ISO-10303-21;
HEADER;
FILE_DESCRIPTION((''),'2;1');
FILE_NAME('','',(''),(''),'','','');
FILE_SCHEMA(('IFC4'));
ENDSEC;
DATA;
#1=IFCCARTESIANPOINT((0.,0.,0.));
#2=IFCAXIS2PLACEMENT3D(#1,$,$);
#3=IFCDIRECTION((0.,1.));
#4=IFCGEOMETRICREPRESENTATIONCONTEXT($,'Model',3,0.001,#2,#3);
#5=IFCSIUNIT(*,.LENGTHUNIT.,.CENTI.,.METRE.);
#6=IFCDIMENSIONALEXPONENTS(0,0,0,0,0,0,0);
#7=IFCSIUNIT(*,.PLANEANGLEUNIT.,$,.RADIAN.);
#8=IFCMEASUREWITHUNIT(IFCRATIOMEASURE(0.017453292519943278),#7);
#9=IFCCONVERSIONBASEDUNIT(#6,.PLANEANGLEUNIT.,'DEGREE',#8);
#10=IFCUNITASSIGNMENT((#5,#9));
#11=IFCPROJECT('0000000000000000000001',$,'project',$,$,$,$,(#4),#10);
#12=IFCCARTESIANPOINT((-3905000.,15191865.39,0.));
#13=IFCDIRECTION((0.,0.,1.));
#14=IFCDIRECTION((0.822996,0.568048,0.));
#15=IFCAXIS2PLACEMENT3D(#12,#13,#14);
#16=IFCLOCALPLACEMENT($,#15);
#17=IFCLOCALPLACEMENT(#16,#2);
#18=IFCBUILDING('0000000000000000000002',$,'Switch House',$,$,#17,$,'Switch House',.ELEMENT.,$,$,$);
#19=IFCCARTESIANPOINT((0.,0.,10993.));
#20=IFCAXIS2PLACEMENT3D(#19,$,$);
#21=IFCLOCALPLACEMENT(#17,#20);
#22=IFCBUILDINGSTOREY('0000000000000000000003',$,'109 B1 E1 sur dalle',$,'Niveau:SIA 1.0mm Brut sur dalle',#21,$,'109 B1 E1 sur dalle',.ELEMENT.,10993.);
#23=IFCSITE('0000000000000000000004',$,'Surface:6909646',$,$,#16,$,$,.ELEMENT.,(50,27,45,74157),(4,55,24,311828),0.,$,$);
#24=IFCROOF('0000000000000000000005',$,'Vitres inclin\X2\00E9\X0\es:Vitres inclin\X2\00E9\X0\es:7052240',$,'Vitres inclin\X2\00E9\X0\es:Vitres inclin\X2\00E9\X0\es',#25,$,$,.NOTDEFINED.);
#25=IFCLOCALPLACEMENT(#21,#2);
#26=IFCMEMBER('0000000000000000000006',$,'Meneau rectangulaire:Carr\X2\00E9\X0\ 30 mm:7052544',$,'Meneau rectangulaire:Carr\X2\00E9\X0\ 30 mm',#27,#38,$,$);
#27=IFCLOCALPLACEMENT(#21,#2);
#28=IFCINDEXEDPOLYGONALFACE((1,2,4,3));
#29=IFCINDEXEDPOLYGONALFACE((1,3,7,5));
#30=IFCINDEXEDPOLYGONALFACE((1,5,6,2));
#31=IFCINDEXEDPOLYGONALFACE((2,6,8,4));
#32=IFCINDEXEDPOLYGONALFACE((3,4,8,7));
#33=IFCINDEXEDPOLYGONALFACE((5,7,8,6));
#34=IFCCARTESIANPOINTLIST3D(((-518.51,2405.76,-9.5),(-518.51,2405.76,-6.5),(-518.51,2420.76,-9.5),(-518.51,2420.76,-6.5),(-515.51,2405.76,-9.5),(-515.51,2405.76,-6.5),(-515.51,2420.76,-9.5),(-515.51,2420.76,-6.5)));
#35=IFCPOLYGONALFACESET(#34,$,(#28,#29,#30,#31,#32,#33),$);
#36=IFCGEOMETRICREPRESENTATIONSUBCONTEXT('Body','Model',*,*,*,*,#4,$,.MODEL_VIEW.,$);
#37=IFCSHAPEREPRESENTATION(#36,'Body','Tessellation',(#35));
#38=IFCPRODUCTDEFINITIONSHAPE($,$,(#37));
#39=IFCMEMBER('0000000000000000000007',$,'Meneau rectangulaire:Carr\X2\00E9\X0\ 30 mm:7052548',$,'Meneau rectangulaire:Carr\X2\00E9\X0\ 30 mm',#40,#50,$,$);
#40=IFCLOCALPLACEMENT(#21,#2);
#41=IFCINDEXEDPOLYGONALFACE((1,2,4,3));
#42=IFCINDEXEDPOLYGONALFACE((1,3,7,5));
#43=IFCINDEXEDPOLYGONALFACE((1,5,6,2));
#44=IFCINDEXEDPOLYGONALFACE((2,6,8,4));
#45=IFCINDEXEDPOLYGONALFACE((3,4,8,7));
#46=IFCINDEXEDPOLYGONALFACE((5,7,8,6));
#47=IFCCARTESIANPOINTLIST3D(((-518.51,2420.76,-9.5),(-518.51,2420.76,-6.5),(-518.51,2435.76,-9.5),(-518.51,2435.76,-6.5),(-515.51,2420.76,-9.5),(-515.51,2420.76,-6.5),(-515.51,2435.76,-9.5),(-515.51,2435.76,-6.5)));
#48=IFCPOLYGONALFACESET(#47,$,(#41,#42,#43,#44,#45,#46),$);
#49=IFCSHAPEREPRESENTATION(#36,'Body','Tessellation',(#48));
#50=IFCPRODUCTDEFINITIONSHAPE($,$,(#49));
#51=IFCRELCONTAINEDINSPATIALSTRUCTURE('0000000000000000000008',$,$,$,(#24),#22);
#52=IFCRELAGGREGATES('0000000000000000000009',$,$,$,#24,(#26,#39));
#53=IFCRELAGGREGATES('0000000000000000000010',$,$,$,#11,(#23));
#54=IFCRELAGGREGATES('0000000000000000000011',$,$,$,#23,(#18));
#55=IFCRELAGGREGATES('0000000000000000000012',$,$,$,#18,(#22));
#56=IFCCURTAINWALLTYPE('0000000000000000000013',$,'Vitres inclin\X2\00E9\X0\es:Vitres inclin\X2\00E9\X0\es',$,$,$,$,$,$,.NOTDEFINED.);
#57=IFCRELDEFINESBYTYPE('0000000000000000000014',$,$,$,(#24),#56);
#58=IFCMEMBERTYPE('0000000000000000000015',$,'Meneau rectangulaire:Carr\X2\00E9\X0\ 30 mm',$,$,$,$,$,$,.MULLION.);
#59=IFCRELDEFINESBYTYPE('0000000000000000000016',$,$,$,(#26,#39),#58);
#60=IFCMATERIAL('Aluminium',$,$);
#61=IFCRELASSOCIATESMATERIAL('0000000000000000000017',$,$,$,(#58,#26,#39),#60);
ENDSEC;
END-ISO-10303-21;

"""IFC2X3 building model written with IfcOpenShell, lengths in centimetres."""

from ifc_helpers import new_model, entity, si_unit, converted_unit, direction, frame, origin, origin_2d_with_axis, place, context, subcontext, project, spatial, rectangle, extrude, source, transform, mapped, material, type_object, type_shapes, element, aggregate, save


model = new_model("IFC2X3")

# Units and contexts
model_context = context("Model", 3, precision=0.001, world=origin(), true_north=direction((0.0, 1.0)))
body_context = subcontext(model_context, "Body", "Model", "MODEL_VIEW")
ifc_project = project(units=[si_unit("LENGTHUNIT", "METRE", prefix="CENTI"), converted_unit("PLANEANGLEUNIT", "DEGREE", entity("IfcRatioMeasure", 0.017453292519943278), si_unit("PLANEANGLEUNIT", "RADIAN"), dimensions=[0, 0, 0, 0, 0, 0, 0])], contexts=[model_context])

# Site, building, storey
site_placement = place(None, frame((-3905000.0, 15191865.39, 0.0), z_axis=(0.0, 0.0, 1.0), x_axis=(0.822996, 0.568048, 0.0)))
site = spatial("IfcSite", under=ifc_project, at=site_placement, Name="Surface:6909646", CompositionType="ELEMENT", RefLatitude=(50, 27, 45, 74157), RefLongitude=(4, 55, 24, 311828), RefElevation=0.0)
building_placement = place(site_placement, origin())
building = spatial("IfcBuilding", under=site, at=building_placement, Name="Switch House", LongName="Switch House", CompositionType="ELEMENT")
storey_placement = place(building_placement, frame((0.0, 0.0, 10993.0)))
storey = spatial("IfcBuildingStorey", under=building, at=storey_placement, Name="109 B1 E1 sur dalle", ObjectType="Niveau:SIA 1.0mm Brut sur dalle", LongName="109 B1 E1 sur dalle", CompositionType="ELEMENT", Elevation=10993.0)

# Roof, members
curtain_wall_type = type_object("IfcCurtainWallType", Name="Vitres inclinées:Vitres inclinées", PredefinedType="NOTDEFINED")
roof_1_placement = place(storey_placement, frame((0.0, 0.0, -10993.0)))
roof_1 = element("IfcRoof", 1, at=roof_1_placement, inside=storey, type_object=curtain_wall_type, Name="Vitres inclinées:Vitres inclinées:7052240", ObjectType="Vitres inclinées:Vitres inclinées", ShapeType="NOTDEFINED")
ifc_material_1 = material(Name="Aluminium")
member_type_1 = type_object("IfcMemberType", Name="Meneau rectangulaire:Carré 30 mm", PredefinedType="MULLION", material=ifc_material_1)
shared_shape_1 = source(origin(), body_context, "Body", "SweptSolid", [
    extrude(rectangle(XDim=3.0, YDim=3.0, at=origin_2d_with_axis()), frame((0.0, 0.0, -15.0), z_axis=(0.0, 0.0, 1.0), x_axis=(0.0, -1.0, 0.0)), (0.0, 0.0, 1.0), 15.0),
])
type_shapes(member_type_1, [shared_shape_1])
member_1_placement = place(roof_1_placement, frame((-517.01, 2420.76, 10985.0), z_axis=(0.0, 1.0, 0.0), x_axis=(1.0, 0.0, 0.0)))
member_1 = element("IfcMember", 2, at=member_1_placement, type_object=member_type_1, material=ifc_material_1, Name="Meneau rectangulaire:Carré 30 mm:7052544", ObjectType="Meneau rectangulaire:Carré 30 mm", context=body_context, shape_type="MappedRepresentation", body=[
    mapped(shared_shape_1, transform((0.0, 0.0, 0.0), scale=1.0)),
])
member_2_placement = place(roof_1_placement, frame((-517.01, 2435.76, 10985.0), z_axis=(0.0, 1.0, 0.0), x_axis=(1.0, 0.0, 0.0)))
member_2 = element("IfcMember", 3, at=member_2_placement, type_object=member_type_1, material=ifc_material_1, Name="Meneau rectangulaire:Carré 30 mm:7052548", ObjectType="Meneau rectangulaire:Carré 30 mm", context=body_context, shape_type="MappedRepresentation", body=[
    mapped(shared_shape_1, transform((0.0, 0.0, 0.0), scale=1.0)),
])
aggregate(roof_1, [member_1, member_2])

save(model, "model.ifc")
